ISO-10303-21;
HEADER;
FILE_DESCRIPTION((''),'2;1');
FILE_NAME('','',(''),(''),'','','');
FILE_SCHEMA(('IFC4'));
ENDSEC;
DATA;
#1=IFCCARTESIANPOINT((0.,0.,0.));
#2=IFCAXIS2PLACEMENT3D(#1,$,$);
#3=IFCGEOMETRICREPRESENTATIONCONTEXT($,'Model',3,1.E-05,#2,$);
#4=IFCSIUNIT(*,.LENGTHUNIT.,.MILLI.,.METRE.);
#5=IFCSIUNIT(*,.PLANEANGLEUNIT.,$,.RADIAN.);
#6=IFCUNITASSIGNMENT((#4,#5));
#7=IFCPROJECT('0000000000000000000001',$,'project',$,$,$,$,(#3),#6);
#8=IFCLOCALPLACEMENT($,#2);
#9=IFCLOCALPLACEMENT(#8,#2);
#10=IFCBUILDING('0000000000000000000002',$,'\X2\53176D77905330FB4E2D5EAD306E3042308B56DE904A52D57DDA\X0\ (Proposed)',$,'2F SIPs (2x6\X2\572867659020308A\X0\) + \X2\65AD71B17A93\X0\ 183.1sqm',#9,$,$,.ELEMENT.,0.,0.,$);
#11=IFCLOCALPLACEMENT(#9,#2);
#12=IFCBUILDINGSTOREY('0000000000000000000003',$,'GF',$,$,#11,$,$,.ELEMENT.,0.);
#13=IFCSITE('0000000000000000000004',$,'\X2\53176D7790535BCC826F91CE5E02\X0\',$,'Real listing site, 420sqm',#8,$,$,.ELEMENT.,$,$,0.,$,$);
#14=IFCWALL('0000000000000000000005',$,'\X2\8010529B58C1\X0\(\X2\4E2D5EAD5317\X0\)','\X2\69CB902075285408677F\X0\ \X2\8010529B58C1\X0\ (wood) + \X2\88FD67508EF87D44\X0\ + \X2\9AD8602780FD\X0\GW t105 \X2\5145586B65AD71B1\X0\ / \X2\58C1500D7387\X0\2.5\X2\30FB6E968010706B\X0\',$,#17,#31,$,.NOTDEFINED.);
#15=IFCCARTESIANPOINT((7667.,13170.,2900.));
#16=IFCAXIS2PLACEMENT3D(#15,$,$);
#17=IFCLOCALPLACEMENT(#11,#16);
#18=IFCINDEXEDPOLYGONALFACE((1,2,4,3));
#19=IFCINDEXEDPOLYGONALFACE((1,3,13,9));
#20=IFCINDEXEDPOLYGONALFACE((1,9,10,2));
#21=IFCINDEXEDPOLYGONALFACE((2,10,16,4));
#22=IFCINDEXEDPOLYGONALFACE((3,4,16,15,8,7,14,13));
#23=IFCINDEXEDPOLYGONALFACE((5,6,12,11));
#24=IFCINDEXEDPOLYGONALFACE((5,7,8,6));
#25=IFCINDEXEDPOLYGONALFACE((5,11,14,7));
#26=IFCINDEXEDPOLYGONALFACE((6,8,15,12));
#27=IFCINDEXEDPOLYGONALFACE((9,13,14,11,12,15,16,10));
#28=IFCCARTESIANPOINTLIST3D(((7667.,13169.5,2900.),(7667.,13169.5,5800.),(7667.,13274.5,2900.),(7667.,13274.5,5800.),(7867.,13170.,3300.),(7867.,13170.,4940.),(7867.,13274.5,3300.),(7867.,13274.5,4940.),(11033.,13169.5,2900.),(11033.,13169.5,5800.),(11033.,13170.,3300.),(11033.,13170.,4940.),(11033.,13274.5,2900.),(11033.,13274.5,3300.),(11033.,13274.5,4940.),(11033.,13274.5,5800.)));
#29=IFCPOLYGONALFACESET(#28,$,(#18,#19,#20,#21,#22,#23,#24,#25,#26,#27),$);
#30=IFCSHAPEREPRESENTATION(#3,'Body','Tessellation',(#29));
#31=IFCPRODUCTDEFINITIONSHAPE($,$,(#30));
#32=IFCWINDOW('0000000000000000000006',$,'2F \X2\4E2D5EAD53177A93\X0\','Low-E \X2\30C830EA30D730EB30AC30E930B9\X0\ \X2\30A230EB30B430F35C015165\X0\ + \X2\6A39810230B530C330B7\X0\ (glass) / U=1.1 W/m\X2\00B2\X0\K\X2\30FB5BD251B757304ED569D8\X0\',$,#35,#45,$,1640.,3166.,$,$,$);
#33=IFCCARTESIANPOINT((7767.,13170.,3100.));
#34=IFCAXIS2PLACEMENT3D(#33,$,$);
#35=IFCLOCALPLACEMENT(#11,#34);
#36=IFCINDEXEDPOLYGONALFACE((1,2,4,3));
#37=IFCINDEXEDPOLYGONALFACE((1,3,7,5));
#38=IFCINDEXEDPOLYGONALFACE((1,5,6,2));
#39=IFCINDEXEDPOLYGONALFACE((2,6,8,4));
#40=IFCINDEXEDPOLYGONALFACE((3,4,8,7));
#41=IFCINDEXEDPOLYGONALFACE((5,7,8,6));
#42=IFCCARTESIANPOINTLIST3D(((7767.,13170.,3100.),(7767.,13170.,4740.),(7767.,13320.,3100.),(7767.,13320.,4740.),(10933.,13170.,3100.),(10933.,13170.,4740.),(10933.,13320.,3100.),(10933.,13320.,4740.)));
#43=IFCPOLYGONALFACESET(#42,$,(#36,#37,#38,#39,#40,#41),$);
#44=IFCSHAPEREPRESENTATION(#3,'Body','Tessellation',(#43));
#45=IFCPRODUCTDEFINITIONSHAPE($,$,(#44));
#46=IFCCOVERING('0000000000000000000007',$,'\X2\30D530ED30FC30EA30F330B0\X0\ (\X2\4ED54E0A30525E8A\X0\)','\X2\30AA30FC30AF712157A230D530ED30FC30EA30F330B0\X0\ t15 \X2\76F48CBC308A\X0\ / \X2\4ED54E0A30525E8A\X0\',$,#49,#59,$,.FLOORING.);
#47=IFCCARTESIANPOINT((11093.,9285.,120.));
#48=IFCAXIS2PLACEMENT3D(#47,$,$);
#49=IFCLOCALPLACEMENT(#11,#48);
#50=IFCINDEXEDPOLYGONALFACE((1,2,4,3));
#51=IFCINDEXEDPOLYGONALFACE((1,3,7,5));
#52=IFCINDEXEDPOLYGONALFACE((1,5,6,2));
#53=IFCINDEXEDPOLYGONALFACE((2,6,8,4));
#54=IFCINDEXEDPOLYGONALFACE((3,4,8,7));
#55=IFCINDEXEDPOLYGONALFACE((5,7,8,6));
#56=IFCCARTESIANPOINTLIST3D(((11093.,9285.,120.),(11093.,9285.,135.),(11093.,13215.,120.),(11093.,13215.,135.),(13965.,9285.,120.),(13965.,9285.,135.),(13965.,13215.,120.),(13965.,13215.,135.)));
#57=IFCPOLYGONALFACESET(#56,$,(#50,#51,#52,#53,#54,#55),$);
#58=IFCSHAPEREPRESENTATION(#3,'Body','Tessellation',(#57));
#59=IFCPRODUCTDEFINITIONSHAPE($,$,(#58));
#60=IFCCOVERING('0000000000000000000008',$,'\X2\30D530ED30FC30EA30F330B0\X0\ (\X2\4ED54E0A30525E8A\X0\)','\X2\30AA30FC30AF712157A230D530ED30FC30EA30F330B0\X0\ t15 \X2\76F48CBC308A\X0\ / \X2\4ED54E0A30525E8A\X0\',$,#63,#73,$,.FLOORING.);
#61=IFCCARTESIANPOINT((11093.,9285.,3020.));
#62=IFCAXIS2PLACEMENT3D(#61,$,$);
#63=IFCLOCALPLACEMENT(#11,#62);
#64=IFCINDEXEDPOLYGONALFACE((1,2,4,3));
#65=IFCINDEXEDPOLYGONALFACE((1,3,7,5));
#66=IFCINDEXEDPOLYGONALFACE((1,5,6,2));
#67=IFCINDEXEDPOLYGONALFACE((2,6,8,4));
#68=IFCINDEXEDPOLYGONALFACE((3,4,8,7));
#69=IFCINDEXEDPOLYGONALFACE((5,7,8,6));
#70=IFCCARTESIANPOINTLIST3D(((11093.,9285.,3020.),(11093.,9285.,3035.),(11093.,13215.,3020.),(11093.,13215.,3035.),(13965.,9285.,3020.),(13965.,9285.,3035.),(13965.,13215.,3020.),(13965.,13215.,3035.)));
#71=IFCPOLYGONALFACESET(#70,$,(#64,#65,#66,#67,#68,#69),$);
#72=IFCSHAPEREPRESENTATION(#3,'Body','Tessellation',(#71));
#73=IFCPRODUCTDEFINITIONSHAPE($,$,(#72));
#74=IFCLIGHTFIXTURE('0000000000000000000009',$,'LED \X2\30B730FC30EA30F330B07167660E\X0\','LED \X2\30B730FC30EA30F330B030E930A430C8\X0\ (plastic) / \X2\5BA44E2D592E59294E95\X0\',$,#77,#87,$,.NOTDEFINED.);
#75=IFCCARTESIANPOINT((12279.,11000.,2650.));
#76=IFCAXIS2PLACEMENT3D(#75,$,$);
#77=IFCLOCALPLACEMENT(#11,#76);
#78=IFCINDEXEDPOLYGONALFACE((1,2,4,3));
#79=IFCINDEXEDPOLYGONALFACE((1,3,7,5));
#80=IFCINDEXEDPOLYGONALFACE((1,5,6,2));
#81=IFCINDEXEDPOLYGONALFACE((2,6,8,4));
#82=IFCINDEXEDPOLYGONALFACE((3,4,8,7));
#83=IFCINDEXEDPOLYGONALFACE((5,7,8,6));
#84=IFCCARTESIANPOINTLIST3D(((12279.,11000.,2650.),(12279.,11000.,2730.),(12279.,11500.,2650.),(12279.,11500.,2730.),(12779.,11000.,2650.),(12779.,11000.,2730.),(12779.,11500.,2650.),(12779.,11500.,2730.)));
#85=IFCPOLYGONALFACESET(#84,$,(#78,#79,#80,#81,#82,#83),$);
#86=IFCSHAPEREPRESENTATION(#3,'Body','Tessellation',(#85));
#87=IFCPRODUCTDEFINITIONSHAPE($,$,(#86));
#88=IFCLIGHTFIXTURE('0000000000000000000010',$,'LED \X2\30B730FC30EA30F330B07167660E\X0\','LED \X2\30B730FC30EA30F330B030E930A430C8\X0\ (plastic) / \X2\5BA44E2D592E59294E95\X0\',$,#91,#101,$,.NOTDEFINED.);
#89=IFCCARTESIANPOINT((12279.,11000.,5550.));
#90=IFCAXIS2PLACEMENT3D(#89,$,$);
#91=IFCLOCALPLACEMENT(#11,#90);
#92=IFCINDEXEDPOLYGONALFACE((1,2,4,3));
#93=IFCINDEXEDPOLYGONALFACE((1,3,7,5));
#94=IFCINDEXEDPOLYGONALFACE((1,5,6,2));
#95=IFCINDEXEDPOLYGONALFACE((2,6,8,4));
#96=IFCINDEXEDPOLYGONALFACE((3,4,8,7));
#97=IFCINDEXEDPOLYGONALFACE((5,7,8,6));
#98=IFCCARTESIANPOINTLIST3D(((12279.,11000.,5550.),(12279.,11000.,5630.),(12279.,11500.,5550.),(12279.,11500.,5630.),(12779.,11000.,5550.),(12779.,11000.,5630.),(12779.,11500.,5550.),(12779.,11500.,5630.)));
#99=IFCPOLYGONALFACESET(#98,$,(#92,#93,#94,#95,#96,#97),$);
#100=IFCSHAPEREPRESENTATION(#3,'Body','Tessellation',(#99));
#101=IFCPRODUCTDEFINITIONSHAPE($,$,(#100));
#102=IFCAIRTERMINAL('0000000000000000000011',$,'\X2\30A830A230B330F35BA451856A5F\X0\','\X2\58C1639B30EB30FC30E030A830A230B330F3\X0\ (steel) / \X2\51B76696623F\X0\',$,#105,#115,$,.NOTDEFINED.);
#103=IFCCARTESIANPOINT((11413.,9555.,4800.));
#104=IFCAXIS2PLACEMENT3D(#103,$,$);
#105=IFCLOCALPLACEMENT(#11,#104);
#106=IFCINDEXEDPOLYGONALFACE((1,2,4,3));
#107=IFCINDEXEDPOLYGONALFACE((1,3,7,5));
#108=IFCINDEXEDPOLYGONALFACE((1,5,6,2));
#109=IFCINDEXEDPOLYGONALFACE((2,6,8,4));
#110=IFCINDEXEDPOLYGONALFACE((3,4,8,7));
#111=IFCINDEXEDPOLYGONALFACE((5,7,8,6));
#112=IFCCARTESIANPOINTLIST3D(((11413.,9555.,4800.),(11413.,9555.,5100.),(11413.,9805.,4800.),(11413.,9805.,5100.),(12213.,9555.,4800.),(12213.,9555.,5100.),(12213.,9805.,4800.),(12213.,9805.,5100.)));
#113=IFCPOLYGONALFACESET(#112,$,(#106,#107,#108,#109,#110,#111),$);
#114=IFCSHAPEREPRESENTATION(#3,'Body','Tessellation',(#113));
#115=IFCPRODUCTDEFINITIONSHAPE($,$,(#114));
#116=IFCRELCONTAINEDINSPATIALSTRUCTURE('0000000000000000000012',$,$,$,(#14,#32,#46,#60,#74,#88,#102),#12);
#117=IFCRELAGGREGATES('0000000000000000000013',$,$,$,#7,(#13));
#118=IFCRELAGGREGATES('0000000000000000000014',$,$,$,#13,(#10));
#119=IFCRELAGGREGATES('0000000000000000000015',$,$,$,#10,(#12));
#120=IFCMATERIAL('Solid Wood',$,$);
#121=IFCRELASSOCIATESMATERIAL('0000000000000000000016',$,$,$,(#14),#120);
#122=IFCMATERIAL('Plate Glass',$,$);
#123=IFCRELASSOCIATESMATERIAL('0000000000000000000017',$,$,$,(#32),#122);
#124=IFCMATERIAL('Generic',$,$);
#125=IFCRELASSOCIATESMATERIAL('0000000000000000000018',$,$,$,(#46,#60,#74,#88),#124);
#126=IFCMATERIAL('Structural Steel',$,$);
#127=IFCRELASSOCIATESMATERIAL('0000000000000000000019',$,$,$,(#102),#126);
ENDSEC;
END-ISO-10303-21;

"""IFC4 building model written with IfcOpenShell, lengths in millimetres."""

from ifc_helpers import new_model, si_unit, frame, frame_2d, origin, place, context, project, spatial, rectangle, extrude, material, element, fill, save


model = new_model("IFC4")

# Units and contexts
model_context = context("Model", 3, precision=1e-05, world=origin())
ifc_project = project(units=[si_unit("LENGTHUNIT", "METRE", prefix="MILLI"), si_unit("PLANEANGLEUNIT", "RADIAN")], contexts=[model_context])

# Site, building, storey
site_placement = place(None, origin())
site = spatial("IfcSite", under=ifc_project, at=site_placement, Name="北海道富良野市", ObjectType="Real listing site, 420sqm", CompositionType="ELEMENT", RefElevation=0.0)
building_placement = place(site_placement, origin())
building = spatial("IfcBuilding", under=site, at=building_placement, Name="北海道・中庭のある回遊動線 (Proposed)", ObjectType="2F SIPs (2x6在来造り) + 断熱窓 183.1sqm", CompositionType="ELEMENT", ElevationOfRefHeight=0.0, ElevationOfTerrain=0.0)
storey_placement = place(building_placement, origin())
storey = spatial("IfcBuildingStorey", under=building, at=storey_placement, Name="GF", CompositionType="ELEMENT", Elevation=0.0)

# Shared definitions
ifc_material_1 = material(Name="Solid Wood")

# Wall, opening, window
ifc_material_2 = material(Name="Plate Glass")
wall_1_placement = place(storey_placement, frame((7667.0, 13170.0, 2900.0)))
wall_1 = element("IfcWall", 1, at=wall_1_placement, inside=storey, material=ifc_material_1, Name="耐力壁(中庭北)", Description="構造用合板 耐力壁 (wood) + 製材軸組 + 高性能GW t105 充填断熱 / 壁倍率2.5・準耐火", PredefinedType="NOTDEFINED", context=model_context, shape_type="SweptSolid", body=[
    extrude(rectangle(XDim=3366.0, YDim=105.0, at=frame_2d((1683.0, 52.0))), frame((7667.0, 13170.0, 2900.0)), (0.0, 0.0, 1.0), 2900.0),
])
opening_1_placement = place(storey_placement, frame((7767.0, 13170.0, 3100.0)))
opening_1 = element("IfcOpeningElement", 2, at=opening_1_placement, cuts=wall_1, PredefinedType="NOTDEFINED", context=model_context, shape_type="SweptSolid", body=[
    extrude(rectangle(XDim=3166.0, YDim=150.0, at=frame_2d((1583.0, 75.0))), frame((7767.0, 13170.0, 3100.0)), (0.0, 0.0, 1.0), 1640.0),
])
window_1_placement = place(storey_placement, frame((7767.0, 13170.0, 3100.0)))
window_1 = element("IfcWindow", 3, at=window_1_placement, inside=storey, material=ifc_material_2, Name="2F 中庭北窓", Description="Low-E トリプルガラス アルゴン封入 + 樹脂サッシ (glass) / U=1.1 W/m²K・寒冷地仕様", OverallHeight=1640.0, OverallWidth=3166.0, context=model_context, shape_type="SweptSolid", body=[
    extrude(rectangle(XDim=3166.0, YDim=150.0, at=frame_2d((1583.0, 75.0))), frame((7767.0, 13170.0, 3100.0)), (0.0, 0.0, 1.0), 1640.0),
])
fill(opening_1, window_1)

# Coverings
ifc_material_3 = material(Name="Generic")
covering_1_placement = place(storey_placement, frame((11093.0, 9285.0, 120.0)))
element("IfcCovering", 4, at=covering_1_placement, inside=storey, material=ifc_material_3, Name="フローリング (仕上げ床)", Description="オーク無垢フローリング t15 直貼り / 仕上げ床", PredefinedType="FLOORING", context=model_context, shape_type="SweptSolid", body=[
    extrude(rectangle(XDim=2872.0, YDim=3930.0, at=frame_2d((1436.0, 1965.0))), frame((11093.0, 9285.0, 120.0)), (0.0, 0.0, 1.0), 15.0),
])
covering_2_placement = place(storey_placement, frame((11093.0, 9285.0, 3020.0)))
element("IfcCovering", 5, at=covering_2_placement, inside=storey, material=ifc_material_3, Name="フローリング (仕上げ床)", Description="オーク無垢フローリング t15 直貼り / 仕上げ床", PredefinedType="FLOORING", context=model_context, shape_type="SweptSolid", body=[
    extrude(rectangle(XDim=2872.0, YDim=3930.0, at=frame_2d((1436.0, 1965.0))), frame((11093.0, 9285.0, 3020.0)), (0.0, 0.0, 1.0), 15.0),
])

# Light fixtures
light_fixture_1_placement = place(storey_placement, frame((12279.0, 11000.0, 2650.0)))
element("IfcLightFixture", 6, at=light_fixture_1_placement, inside=storey, material=ifc_material_3, Name="LED シーリング照明", Description="LED シーリングライト (plastic) / 室中央天井", PredefinedType="NOTDEFINED", context=model_context, shape_type="SweptSolid", body=[
    extrude(rectangle(XDim=500.0, YDim=500.0, at=frame_2d((250.0, 250.0))), frame((12279.0, 11000.0, 2650.0)), (0.0, 0.0, 1.0), 80.0),
])
light_fixture_2_placement = place(storey_placement, frame((12279.0, 11000.0, 5550.0)))
element("IfcLightFixture", 7, at=light_fixture_2_placement, inside=storey, material=ifc_material_3, Name="LED シーリング照明", Description="LED シーリングライト (plastic) / 室中央天井", PredefinedType="NOTDEFINED", context=model_context, shape_type="SweptSolid", body=[
    extrude(rectangle(XDim=500.0, YDim=500.0, at=frame_2d((250.0, 250.0))), frame((12279.0, 11000.0, 5550.0)), (0.0, 0.0, 1.0), 80.0),
])

# Air terminal
ifc_material_4 = material(Name="Structural Steel")
air_terminal_placement = place(storey_placement, frame((11413.0, 9555.0, 4800.0)))
element("IfcAirTerminal", 8, at=air_terminal_placement, inside=storey, material=ifc_material_4, Name="エアコン室内機", Description="壁掛ルームエアコン (steel) / 冷暖房", PredefinedType="NOTDEFINED", context=model_context, shape_type="SweptSolid", body=[
    extrude(rectangle(XDim=800.0, YDim=250.0, at=frame_2d((400.0, 125.0))), frame((11413.0, 9555.0, 4800.0)), (0.0, 0.0, 1.0), 300.0),
])

save(model, "model.ifc")
